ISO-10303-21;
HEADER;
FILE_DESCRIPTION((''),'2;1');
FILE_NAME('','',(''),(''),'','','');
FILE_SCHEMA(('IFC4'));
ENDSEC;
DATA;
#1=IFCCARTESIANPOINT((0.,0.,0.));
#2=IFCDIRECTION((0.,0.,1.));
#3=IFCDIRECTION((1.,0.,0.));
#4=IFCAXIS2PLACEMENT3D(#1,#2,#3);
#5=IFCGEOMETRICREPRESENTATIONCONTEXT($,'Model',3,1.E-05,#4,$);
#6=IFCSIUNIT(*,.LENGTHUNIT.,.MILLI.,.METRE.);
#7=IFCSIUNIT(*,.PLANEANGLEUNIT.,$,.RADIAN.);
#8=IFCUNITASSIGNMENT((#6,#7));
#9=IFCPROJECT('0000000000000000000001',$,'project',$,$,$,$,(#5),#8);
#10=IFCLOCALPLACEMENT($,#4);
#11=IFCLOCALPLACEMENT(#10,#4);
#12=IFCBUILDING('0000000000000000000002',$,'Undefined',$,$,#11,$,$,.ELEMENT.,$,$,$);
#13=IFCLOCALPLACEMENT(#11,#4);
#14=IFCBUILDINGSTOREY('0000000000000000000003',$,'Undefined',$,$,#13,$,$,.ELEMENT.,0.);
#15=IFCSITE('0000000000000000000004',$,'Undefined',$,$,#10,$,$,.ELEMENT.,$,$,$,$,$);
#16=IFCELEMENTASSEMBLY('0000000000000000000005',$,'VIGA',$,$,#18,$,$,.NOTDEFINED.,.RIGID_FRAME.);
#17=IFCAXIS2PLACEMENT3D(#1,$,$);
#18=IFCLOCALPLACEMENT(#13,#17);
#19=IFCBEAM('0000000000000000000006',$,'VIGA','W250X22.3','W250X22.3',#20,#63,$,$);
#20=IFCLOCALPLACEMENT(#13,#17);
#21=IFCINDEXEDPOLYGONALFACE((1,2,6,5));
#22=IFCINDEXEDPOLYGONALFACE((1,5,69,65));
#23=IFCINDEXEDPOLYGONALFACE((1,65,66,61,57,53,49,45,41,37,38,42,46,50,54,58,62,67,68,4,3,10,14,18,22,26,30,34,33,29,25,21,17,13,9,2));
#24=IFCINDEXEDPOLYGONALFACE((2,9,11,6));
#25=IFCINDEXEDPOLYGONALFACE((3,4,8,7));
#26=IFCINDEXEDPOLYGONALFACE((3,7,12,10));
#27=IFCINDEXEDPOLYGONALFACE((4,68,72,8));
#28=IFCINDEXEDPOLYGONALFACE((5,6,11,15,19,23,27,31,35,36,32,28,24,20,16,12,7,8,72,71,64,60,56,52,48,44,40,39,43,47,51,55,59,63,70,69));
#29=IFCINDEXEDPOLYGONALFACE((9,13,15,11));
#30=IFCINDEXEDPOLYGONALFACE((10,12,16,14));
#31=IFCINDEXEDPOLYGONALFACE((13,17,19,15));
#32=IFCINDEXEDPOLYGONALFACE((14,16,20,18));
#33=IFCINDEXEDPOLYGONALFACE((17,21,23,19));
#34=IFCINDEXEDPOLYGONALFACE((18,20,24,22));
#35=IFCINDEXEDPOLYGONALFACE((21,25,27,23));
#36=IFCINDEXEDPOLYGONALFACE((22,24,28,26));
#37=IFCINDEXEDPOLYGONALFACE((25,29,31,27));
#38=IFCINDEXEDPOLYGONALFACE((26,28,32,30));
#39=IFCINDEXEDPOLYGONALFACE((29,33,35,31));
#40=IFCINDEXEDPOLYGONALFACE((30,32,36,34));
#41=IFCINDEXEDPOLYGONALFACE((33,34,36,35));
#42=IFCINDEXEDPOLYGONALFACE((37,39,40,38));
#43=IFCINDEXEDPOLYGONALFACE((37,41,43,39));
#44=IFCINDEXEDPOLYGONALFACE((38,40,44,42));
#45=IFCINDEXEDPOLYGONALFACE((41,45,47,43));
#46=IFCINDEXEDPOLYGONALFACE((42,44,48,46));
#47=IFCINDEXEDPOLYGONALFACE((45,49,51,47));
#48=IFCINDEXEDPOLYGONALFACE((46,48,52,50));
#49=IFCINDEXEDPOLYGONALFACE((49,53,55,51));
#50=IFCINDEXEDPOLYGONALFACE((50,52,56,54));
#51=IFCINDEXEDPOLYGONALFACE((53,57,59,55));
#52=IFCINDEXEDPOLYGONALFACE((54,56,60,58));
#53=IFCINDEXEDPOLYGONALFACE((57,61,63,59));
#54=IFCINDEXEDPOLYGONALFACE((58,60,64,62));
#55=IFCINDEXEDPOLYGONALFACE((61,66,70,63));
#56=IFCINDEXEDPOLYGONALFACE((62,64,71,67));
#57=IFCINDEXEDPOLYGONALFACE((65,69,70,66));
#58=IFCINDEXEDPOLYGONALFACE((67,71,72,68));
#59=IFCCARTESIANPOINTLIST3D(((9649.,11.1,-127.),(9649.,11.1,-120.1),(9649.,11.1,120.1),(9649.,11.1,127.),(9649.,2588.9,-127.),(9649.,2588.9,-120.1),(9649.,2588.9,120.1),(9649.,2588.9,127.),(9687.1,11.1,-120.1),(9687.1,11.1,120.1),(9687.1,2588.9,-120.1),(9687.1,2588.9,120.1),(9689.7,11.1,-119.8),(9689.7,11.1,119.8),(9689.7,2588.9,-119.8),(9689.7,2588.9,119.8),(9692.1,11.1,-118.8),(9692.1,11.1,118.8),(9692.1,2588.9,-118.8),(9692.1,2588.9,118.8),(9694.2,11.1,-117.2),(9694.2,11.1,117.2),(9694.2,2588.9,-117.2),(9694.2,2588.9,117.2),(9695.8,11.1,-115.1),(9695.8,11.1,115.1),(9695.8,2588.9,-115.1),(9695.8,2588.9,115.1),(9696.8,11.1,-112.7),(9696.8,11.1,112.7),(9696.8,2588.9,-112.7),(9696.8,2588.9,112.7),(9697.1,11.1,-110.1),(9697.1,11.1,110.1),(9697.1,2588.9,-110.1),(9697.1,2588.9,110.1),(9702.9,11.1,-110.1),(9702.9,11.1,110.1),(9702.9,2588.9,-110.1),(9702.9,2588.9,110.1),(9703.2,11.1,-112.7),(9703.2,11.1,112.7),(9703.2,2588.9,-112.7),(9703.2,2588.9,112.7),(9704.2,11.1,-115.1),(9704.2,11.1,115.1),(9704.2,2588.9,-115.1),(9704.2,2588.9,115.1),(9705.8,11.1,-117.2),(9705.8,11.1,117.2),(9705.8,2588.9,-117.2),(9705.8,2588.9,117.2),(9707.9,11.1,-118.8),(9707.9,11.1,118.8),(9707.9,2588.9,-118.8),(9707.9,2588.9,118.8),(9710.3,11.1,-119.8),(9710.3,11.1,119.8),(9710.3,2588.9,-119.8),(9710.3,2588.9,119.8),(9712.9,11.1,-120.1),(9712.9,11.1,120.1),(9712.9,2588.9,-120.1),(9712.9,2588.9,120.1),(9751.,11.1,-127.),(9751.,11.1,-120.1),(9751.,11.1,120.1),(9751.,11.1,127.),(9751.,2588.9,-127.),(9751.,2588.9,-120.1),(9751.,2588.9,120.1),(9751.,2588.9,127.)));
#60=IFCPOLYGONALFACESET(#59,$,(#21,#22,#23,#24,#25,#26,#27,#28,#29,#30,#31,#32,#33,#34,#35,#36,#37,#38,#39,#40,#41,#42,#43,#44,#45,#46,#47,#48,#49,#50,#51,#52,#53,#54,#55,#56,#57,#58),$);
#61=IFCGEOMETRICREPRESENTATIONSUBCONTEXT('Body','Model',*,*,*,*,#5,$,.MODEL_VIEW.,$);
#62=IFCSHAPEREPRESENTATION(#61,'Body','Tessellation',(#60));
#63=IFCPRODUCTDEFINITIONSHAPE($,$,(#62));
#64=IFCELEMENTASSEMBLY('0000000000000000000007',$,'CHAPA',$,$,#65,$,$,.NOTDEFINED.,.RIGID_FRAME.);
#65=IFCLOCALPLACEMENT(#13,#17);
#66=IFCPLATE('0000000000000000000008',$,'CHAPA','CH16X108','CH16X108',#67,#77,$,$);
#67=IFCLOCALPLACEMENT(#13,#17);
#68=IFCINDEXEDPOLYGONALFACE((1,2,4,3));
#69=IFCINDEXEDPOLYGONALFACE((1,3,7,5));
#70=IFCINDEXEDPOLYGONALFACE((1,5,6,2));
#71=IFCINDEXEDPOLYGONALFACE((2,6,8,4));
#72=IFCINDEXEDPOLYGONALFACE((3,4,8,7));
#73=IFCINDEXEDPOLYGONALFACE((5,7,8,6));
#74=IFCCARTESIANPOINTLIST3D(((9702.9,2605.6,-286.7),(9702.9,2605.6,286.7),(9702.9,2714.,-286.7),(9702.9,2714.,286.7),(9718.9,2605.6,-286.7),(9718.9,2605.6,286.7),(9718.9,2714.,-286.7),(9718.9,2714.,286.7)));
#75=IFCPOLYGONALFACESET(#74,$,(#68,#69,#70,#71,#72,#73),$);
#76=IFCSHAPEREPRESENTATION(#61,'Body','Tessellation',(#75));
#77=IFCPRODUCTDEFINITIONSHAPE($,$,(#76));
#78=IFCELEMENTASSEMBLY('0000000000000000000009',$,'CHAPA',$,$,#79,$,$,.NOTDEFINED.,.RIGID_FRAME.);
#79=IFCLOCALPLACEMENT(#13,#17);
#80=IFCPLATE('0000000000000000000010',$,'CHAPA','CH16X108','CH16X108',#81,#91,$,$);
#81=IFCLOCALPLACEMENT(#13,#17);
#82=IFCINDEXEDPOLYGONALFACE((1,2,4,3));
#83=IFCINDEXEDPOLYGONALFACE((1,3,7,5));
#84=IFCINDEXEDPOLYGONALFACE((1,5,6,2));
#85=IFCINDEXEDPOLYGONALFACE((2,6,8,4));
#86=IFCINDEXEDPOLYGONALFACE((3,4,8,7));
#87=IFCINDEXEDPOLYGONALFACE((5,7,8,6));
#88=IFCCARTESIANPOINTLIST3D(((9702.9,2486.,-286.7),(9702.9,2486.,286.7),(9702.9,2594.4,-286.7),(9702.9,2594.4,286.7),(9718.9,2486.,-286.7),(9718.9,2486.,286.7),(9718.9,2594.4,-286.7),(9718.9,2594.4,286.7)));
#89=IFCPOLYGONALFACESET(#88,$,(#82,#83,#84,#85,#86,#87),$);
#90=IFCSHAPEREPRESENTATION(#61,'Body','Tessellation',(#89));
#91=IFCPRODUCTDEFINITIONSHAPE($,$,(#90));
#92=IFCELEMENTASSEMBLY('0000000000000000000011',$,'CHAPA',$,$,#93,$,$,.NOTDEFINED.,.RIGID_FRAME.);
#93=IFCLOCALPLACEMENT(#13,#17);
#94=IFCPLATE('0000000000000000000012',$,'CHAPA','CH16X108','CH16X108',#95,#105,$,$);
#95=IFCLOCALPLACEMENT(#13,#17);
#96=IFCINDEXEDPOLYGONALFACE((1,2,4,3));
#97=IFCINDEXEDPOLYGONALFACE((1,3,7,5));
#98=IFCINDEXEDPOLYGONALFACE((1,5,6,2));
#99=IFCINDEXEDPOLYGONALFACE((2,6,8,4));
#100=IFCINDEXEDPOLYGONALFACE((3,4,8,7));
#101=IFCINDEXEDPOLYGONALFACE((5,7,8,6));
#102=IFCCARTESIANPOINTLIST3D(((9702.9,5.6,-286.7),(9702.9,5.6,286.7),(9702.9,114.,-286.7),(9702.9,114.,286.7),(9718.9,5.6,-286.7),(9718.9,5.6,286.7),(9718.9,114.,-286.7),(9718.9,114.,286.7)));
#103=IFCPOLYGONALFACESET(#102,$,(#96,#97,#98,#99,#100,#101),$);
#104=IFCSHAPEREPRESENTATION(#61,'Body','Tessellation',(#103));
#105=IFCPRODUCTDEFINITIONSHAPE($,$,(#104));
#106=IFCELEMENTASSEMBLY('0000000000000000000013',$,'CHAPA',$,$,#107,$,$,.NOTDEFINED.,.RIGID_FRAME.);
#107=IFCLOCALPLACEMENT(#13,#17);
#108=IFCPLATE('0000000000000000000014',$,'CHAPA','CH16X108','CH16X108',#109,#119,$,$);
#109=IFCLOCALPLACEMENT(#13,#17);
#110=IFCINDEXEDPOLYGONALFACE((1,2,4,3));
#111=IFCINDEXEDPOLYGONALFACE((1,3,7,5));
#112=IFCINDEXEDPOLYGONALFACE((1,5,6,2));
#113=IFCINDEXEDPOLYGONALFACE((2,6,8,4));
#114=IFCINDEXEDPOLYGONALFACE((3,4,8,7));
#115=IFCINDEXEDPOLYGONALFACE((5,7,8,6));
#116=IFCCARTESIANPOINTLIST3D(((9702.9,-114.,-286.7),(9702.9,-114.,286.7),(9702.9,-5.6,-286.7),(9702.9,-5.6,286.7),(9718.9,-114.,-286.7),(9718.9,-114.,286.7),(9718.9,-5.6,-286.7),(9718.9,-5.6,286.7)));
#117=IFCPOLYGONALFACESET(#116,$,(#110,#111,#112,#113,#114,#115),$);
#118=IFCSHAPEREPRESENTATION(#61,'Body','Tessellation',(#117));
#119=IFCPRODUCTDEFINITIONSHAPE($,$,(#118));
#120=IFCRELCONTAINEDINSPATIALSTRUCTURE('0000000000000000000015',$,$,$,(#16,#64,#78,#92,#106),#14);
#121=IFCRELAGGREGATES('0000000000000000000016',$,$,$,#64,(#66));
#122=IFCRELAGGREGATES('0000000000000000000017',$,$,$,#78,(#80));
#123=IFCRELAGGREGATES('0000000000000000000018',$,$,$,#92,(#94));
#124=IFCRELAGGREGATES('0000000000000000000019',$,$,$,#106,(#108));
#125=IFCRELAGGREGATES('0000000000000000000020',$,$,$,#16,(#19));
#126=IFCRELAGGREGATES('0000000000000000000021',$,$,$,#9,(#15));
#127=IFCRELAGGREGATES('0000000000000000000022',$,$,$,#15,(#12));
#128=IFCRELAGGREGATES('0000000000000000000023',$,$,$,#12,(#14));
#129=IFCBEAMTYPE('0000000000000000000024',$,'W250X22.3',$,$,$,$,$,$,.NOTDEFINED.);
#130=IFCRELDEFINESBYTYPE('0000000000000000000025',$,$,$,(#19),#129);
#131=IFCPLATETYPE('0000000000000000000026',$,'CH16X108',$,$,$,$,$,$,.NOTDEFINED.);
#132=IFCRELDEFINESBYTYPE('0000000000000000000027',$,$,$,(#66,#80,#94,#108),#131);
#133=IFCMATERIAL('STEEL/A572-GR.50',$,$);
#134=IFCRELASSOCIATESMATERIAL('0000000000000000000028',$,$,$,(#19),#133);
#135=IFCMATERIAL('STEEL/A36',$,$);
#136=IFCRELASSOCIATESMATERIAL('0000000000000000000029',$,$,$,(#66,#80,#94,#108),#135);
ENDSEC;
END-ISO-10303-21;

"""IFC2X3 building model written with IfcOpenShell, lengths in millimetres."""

from ifc_helpers import new_model, si_unit, frame, origin_with_axes, origin_2d_with_axis, place, context, subcontext, project, spatial, polyline, i_section, outline, extrude, material, type_object, element, aggregate, save


model = new_model("IFC2X3")

# Units and contexts
model_context = context("Model", 3, precision=1e-05, world=origin_with_axes())
body_context = subcontext(model_context, "Body", "Model", "MODEL_VIEW")
ifc_project = project(units=[si_unit("LENGTHUNIT", "METRE", prefix="MILLI"), si_unit("PLANEANGLEUNIT", "RADIAN")], contexts=[model_context])

# Site, building, storey
site_placement = place(None, origin_with_axes())
site = spatial("IfcSite", under=ifc_project, at=site_placement, Name="Undefined", CompositionType="ELEMENT")
building_placement = place(site_placement, origin_with_axes())
building = spatial("IfcBuilding", under=site, at=building_placement, Name="Undefined", CompositionType="ELEMENT")
storey_placement = place(building_placement, origin_with_axes())
storey = spatial("IfcBuildingStorey", under=building, at=storey_placement, Name="Undefined", CompositionType="ELEMENT", Elevation=0.0)

# Element assembly, beam
ifc_material_1 = material(Name="STEEL/A572-GR.50")
assembly_1_placement = place(storey_placement, origin_with_axes())
assembly_1 = element("IfcElementAssembly", 1, at=assembly_1_placement, inside=storey, Name="VIGA", AssemblyPlace="NOTDEFINED", PredefinedType="RIGID_FRAME")
beam_type_1 = type_object("IfcBeamType", Name="W250X22.3", PredefinedType="NOTDEFINED")
beam_1_placement = place(assembly_1_placement, frame((9700.0, 11.1, 0.0), z_axis=(0.0, 0.0, 1.0), x_axis=(0.0, 1.0, 0.0)))
beam_1 = element("IfcBeam", 2, at=beam_1_placement, type_object=beam_type_1, material=ifc_material_1, Name="VIGA", Description="W250X22.3", ObjectType="W250X22.3", context=body_context, shape_type="SweptSolid", body=[
    extrude(i_section(OverallWidth=102.0, OverallDepth=254.0, WebThickness=5.8, FlangeThickness=6.9, FilletRadius=10.0, at=origin_2d_with_axis()), frame((2577.8, 0.0, 0.0), z_axis=(-1.0, 0.0, 0.0), x_axis=(0.0, -1.0, 0.0)), (0.0, 0.0, 1.0), 2577.8),
])

# Element assemblies, plates
assembly_2_placement = place(storey_placement, origin_with_axes())
assembly_2 = element("IfcElementAssembly", 3, at=assembly_2_placement, inside=storey, Name="CHAPA", AssemblyPlace="NOTDEFINED", PredefinedType="RIGID_FRAME")
ifc_material_2 = material(Name="STEEL/A36")
plate_type = type_object("IfcPlateType", Name="CH16X108", PredefinedType="NOTDEFINED")
plate_1_placement = place(assembly_2_placement, frame((9710.9, 2605.6, 286.7), z_axis=(-1.0, 0.0, 0.0), x_axis=(0.0, 1.0, 0.0)))
plate_1 = element("IfcPlate", 4, at=plate_1_placement, type_object=plate_type, material=ifc_material_2, Name="CHAPA", Description="CH16X108", ObjectType="CH16X108", context=body_context, shape_type="SweptSolid", body=[
    extrude(outline(polyline([(0.0, 0.0), (108.4, 0.0), (108.4, 573.4), (0.0, 573.4), (0.0, 0.0)])), frame((0.0, 0.0, -8.0), z_axis=(0.0, 0.0, 1.0), x_axis=(1.0, 0.0, 0.0)), (0.0, 0.0, 1.0), 16.0),
])
aggregate(assembly_2, [plate_1])
assembly_3_placement = place(storey_placement, origin_with_axes())
assembly_3 = element("IfcElementAssembly", 5, at=assembly_3_placement, inside=storey, Name="CHAPA", AssemblyPlace="NOTDEFINED", PredefinedType="RIGID_FRAME")
plate_2_placement = place(assembly_3_placement, frame((9710.9, 2486.0, 286.7), z_axis=(-1.0, 0.0, 0.0), x_axis=(0.0, 1.0, 0.0)))
plate_2 = element("IfcPlate", 6, at=plate_2_placement, type_object=plate_type, material=ifc_material_2, Name="CHAPA", Description="CH16X108", ObjectType="CH16X108", context=body_context, shape_type="SweptSolid", body=[
    extrude(outline(polyline([(0.0, 0.0), (108.4, 0.0), (108.4, 573.4), (0.0, 573.4), (0.0, 0.0)])), frame((0.0, 0.0, -8.0), z_axis=(0.0, 0.0, 1.0), x_axis=(1.0, 0.0, 0.0)), (0.0, 0.0, 1.0), 16.0),
])
aggregate(assembly_3, [plate_2])
assembly_4_placement = place(storey_placement, origin_with_axes())
assembly_4 = element("IfcElementAssembly", 7, at=assembly_4_placement, inside=storey, Name="CHAPA", AssemblyPlace="NOTDEFINED", PredefinedType="RIGID_FRAME")
plate_3_placement = place(assembly_4_placement, frame((9710.9, 5.6, 286.7), z_axis=(-1.0, 0.0, 0.0), x_axis=(0.0, 1.0, 0.0)))
plate_3 = element("IfcPlate", 8, at=plate_3_placement, type_object=plate_type, material=ifc_material_2, Name="CHAPA", Description="CH16X108", ObjectType="CH16X108", context=body_context, shape_type="SweptSolid", body=[
    extrude(outline(polyline([(0.0, 0.0), (108.4, 0.0), (108.4, 573.4), (0.0, 573.4), (0.0, 0.0)])), frame((0.0, 0.0, -8.0), z_axis=(0.0, 0.0, 1.0), x_axis=(1.0, 0.0, 0.0)), (0.0, 0.0, 1.0), 16.0),
])
aggregate(assembly_4, [plate_3])
assembly_5_placement = place(storey_placement, origin_with_axes())
assembly_5 = element("IfcElementAssembly", 9, at=assembly_5_placement, inside=storey, Name="CHAPA", AssemblyPlace="NOTDEFINED", PredefinedType="RIGID_FRAME")
plate_4_placement = place(assembly_5_placement, frame((9710.9, -114.0, 286.7), z_axis=(-1.0, 0.0, 0.0), x_axis=(0.0, 1.0, 0.0)))
plate_4 = element("IfcPlate", 10, at=plate_4_placement, type_object=plate_type, material=ifc_material_2, Name="CHAPA", Description="CH16X108", ObjectType="CH16X108", context=body_context, shape_type="SweptSolid", body=[
    extrude(outline(polyline([(0.0, 0.0), (108.4, 0.0), (108.4, 573.4), (0.0, 573.4), (0.0, 0.0)])), frame((0.0, 0.0, -8.0), z_axis=(0.0, 0.0, 1.0), x_axis=(1.0, 0.0, 0.0)), (0.0, 0.0, 1.0), 16.0),
])
aggregate(assembly_5, [plate_4])

aggregate(assembly_1, [beam_1])

save(model, "model.ifc")
